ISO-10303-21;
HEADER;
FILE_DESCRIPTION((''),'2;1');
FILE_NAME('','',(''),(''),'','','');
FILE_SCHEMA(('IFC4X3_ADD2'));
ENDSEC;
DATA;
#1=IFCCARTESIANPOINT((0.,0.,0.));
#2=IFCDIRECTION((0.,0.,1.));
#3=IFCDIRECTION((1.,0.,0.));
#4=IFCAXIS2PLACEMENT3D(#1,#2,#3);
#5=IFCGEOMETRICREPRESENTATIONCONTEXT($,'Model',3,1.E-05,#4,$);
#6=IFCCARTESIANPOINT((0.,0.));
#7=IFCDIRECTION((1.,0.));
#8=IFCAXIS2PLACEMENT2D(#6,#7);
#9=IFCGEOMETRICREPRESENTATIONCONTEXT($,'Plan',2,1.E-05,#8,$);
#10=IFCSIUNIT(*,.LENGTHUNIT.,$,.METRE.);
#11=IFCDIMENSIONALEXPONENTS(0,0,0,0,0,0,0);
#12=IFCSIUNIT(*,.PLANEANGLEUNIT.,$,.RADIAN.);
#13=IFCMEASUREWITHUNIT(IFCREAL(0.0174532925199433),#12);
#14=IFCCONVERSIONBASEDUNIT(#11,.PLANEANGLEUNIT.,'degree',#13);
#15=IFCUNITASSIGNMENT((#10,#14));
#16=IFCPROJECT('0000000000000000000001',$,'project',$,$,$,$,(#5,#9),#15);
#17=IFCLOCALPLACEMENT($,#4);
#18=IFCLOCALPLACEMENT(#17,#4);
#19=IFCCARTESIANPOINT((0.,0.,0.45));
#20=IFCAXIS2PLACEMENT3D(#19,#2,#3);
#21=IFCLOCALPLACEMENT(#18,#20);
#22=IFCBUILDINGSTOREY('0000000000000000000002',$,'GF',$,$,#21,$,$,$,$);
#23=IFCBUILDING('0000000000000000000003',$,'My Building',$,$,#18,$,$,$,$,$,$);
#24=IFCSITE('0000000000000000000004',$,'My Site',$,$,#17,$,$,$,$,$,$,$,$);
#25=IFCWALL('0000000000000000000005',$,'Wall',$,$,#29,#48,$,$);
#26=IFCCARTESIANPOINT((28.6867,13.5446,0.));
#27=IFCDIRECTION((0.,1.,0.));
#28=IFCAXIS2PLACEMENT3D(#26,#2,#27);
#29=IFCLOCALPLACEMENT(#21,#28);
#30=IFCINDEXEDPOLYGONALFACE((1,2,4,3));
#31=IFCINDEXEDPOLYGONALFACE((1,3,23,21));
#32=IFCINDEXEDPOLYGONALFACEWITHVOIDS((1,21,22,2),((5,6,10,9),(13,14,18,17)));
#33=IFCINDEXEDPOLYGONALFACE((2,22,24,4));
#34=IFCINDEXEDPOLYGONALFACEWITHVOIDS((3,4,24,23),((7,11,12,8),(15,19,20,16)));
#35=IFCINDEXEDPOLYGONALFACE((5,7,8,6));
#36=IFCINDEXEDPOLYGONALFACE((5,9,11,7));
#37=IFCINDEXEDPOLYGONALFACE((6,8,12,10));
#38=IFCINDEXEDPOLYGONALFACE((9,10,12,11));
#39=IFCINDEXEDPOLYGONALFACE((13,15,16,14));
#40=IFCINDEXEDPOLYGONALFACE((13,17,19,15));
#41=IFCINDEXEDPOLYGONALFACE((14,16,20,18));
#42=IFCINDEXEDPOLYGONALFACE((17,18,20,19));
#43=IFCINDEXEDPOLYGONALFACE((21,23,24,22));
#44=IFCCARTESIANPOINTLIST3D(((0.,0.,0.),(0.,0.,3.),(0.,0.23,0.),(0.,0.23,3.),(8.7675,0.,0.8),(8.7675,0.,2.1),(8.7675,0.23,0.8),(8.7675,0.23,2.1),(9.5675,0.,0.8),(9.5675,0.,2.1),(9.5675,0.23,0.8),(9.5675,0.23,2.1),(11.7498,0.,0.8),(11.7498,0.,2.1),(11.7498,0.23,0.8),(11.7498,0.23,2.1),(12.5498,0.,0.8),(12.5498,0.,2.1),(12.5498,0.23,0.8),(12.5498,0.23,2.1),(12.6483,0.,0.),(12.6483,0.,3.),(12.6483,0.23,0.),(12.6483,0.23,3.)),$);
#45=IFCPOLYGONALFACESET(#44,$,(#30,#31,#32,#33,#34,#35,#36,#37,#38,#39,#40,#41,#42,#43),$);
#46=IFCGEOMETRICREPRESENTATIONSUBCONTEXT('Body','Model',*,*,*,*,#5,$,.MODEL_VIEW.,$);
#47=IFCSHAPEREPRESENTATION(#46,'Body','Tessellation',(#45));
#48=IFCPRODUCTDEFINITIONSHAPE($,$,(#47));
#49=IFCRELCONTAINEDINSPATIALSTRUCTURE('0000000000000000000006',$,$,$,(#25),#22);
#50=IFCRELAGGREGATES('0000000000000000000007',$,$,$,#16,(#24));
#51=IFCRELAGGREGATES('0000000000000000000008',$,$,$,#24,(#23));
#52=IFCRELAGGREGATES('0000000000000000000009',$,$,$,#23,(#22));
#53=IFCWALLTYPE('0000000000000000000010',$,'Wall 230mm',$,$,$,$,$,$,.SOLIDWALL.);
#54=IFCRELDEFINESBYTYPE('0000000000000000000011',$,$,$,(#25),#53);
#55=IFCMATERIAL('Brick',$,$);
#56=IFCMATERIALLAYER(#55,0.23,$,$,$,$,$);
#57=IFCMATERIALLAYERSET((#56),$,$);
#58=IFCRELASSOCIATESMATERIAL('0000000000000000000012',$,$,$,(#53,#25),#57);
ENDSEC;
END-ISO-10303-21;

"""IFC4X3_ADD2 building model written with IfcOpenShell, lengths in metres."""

from ifc_helpers import new_model, entity, si_unit, converted_unit, frame, origin_with_axes, origin_2d_with_axis, place, context, subcontext, project, spatial, line, indexed_curve, outline, extrude, source, transform, mapped, material, layer, layer_set, layer_usage, type_object, element, save


model = new_model("IFC4X3_ADD2")

# Units and contexts
model_context = context("Model", 3, precision=1e-05, world=origin_with_axes())
plan_context = context("Plan", 2, precision=1e-05, world=origin_2d_with_axis())
body_context_1 = subcontext(model_context, "Body", "Model", "MODEL_VIEW")
ifc_project = project(units=[si_unit("LENGTHUNIT", "METRE"), converted_unit("PLANEANGLEUNIT", "degree", entity("IfcReal", 0.0174532925199433), si_unit("PLANEANGLEUNIT", "RADIAN"), dimensions=[0, 0, 0, 0, 0, 0, 0])], contexts=[model_context, plan_context])

# Site, building, storey
site_placement = place(None, origin_with_axes())
site = spatial("IfcSite", under=ifc_project, at=site_placement, Name="My Site")
building_placement = place(site_placement, origin_with_axes())
building = spatial("IfcBuilding", under=site, at=building_placement, Name="My Building")
storey_placement = place(building_placement, frame((0.0, 0.0, 0.45), z_axis=(0.0, 0.0, 1.0), x_axis=(1.0, 0.0, 0.0)))
storey = spatial("IfcBuildingStorey", under=building, at=storey_placement, Name="GF")

# Wall, openings
ifc_material_1 = material(Name="Brick")
ifc_layer_1 = layer(ifc_material_1, 0.23)
ifc_layer_set_1 = layer_set([ifc_layer_1])
ifc_layer_usage_1 = layer_usage(ifc_layer_set_1, "AXIS2", "POSITIVE", 0.0)
wall_type_1 = type_object("IfcWallType", Name="Wall 230mm", PredefinedType="SOLIDWALL", material=ifc_layer_set_1)
wall_1_placement = place(storey_placement, frame((28.6867, 13.5446, 0.0), z_axis=(0.0, 0.0, 1.0), x_axis=(0.0, 1.0, 0.0)))
wall_1 = element("IfcWall", 1, at=wall_1_placement, inside=storey, type_object=wall_type_1, material=ifc_layer_usage_1, Name="Wall", context=body_context_1, shape_type="SweptSolid", body=[
    extrude(outline(indexed_curve([(0.0, 0.0), (0.0, 0.23), (12.6483, 0.23), (12.6483, 0.0), (0.0, 0.0)], self_intersect=False)), origin_with_axes(), (0.0, 0.0, 1.0), 3.0),
])
shared_shape_1 = source(origin_with_axes(), body_context_1, "Body", "SweptSolid", [
    extrude(outline(indexed_curve([(0.0, 0.0), (0.8, 0.0), (0.8, 1.3), (0.0, 1.3)], segments=[line(1, 2, 3, 4, 1)])), frame((-0.4, -0.6, 0.0), z_axis=(0.0, -1.0, 0.0), x_axis=(1.0, 0.0, 0.0)), (0.0, 0.0, -1.0), 1.2),
])
opening_1_placement = place(wall_1_placement, frame((9.1675, 0.16, 0.8), z_axis=(0.0, 0.0, 1.0), x_axis=(1.0, 0.0, 0.0)))
element("IfcOpeningElement", 2, at=opening_1_placement, cuts=wall_1, PredefinedType="OPENING", context=body_context_1, shape_type="MappedRepresentation", body=[
    mapped(shared_shape_1, transform((0.0, 0.0, 0.0), x_axis=(1.0, 0.0, 0.0), y_axis=(0.0, 1.0, 0.0), z_axis=(0.0, 0.0, 1.0), scale=1.0)),
])
opening_2_placement = place(wall_1_placement, frame((12.1498, 0.16, 0.8), z_axis=(0.0, 0.0, 1.0), x_axis=(1.0, 0.0, 0.0)))
element("IfcOpeningElement", 3, at=opening_2_placement, cuts=wall_1, PredefinedType="OPENING", context=body_context_1, shape_type="MappedRepresentation", body=[
    mapped(shared_shape_1, transform((0.0, 0.0, 0.0), x_axis=(1.0, 0.0, 0.0), y_axis=(0.0, 1.0, 0.0), z_axis=(0.0, 0.0, 1.0), scale=1.0)),
])

save(model, "model.ifc")
